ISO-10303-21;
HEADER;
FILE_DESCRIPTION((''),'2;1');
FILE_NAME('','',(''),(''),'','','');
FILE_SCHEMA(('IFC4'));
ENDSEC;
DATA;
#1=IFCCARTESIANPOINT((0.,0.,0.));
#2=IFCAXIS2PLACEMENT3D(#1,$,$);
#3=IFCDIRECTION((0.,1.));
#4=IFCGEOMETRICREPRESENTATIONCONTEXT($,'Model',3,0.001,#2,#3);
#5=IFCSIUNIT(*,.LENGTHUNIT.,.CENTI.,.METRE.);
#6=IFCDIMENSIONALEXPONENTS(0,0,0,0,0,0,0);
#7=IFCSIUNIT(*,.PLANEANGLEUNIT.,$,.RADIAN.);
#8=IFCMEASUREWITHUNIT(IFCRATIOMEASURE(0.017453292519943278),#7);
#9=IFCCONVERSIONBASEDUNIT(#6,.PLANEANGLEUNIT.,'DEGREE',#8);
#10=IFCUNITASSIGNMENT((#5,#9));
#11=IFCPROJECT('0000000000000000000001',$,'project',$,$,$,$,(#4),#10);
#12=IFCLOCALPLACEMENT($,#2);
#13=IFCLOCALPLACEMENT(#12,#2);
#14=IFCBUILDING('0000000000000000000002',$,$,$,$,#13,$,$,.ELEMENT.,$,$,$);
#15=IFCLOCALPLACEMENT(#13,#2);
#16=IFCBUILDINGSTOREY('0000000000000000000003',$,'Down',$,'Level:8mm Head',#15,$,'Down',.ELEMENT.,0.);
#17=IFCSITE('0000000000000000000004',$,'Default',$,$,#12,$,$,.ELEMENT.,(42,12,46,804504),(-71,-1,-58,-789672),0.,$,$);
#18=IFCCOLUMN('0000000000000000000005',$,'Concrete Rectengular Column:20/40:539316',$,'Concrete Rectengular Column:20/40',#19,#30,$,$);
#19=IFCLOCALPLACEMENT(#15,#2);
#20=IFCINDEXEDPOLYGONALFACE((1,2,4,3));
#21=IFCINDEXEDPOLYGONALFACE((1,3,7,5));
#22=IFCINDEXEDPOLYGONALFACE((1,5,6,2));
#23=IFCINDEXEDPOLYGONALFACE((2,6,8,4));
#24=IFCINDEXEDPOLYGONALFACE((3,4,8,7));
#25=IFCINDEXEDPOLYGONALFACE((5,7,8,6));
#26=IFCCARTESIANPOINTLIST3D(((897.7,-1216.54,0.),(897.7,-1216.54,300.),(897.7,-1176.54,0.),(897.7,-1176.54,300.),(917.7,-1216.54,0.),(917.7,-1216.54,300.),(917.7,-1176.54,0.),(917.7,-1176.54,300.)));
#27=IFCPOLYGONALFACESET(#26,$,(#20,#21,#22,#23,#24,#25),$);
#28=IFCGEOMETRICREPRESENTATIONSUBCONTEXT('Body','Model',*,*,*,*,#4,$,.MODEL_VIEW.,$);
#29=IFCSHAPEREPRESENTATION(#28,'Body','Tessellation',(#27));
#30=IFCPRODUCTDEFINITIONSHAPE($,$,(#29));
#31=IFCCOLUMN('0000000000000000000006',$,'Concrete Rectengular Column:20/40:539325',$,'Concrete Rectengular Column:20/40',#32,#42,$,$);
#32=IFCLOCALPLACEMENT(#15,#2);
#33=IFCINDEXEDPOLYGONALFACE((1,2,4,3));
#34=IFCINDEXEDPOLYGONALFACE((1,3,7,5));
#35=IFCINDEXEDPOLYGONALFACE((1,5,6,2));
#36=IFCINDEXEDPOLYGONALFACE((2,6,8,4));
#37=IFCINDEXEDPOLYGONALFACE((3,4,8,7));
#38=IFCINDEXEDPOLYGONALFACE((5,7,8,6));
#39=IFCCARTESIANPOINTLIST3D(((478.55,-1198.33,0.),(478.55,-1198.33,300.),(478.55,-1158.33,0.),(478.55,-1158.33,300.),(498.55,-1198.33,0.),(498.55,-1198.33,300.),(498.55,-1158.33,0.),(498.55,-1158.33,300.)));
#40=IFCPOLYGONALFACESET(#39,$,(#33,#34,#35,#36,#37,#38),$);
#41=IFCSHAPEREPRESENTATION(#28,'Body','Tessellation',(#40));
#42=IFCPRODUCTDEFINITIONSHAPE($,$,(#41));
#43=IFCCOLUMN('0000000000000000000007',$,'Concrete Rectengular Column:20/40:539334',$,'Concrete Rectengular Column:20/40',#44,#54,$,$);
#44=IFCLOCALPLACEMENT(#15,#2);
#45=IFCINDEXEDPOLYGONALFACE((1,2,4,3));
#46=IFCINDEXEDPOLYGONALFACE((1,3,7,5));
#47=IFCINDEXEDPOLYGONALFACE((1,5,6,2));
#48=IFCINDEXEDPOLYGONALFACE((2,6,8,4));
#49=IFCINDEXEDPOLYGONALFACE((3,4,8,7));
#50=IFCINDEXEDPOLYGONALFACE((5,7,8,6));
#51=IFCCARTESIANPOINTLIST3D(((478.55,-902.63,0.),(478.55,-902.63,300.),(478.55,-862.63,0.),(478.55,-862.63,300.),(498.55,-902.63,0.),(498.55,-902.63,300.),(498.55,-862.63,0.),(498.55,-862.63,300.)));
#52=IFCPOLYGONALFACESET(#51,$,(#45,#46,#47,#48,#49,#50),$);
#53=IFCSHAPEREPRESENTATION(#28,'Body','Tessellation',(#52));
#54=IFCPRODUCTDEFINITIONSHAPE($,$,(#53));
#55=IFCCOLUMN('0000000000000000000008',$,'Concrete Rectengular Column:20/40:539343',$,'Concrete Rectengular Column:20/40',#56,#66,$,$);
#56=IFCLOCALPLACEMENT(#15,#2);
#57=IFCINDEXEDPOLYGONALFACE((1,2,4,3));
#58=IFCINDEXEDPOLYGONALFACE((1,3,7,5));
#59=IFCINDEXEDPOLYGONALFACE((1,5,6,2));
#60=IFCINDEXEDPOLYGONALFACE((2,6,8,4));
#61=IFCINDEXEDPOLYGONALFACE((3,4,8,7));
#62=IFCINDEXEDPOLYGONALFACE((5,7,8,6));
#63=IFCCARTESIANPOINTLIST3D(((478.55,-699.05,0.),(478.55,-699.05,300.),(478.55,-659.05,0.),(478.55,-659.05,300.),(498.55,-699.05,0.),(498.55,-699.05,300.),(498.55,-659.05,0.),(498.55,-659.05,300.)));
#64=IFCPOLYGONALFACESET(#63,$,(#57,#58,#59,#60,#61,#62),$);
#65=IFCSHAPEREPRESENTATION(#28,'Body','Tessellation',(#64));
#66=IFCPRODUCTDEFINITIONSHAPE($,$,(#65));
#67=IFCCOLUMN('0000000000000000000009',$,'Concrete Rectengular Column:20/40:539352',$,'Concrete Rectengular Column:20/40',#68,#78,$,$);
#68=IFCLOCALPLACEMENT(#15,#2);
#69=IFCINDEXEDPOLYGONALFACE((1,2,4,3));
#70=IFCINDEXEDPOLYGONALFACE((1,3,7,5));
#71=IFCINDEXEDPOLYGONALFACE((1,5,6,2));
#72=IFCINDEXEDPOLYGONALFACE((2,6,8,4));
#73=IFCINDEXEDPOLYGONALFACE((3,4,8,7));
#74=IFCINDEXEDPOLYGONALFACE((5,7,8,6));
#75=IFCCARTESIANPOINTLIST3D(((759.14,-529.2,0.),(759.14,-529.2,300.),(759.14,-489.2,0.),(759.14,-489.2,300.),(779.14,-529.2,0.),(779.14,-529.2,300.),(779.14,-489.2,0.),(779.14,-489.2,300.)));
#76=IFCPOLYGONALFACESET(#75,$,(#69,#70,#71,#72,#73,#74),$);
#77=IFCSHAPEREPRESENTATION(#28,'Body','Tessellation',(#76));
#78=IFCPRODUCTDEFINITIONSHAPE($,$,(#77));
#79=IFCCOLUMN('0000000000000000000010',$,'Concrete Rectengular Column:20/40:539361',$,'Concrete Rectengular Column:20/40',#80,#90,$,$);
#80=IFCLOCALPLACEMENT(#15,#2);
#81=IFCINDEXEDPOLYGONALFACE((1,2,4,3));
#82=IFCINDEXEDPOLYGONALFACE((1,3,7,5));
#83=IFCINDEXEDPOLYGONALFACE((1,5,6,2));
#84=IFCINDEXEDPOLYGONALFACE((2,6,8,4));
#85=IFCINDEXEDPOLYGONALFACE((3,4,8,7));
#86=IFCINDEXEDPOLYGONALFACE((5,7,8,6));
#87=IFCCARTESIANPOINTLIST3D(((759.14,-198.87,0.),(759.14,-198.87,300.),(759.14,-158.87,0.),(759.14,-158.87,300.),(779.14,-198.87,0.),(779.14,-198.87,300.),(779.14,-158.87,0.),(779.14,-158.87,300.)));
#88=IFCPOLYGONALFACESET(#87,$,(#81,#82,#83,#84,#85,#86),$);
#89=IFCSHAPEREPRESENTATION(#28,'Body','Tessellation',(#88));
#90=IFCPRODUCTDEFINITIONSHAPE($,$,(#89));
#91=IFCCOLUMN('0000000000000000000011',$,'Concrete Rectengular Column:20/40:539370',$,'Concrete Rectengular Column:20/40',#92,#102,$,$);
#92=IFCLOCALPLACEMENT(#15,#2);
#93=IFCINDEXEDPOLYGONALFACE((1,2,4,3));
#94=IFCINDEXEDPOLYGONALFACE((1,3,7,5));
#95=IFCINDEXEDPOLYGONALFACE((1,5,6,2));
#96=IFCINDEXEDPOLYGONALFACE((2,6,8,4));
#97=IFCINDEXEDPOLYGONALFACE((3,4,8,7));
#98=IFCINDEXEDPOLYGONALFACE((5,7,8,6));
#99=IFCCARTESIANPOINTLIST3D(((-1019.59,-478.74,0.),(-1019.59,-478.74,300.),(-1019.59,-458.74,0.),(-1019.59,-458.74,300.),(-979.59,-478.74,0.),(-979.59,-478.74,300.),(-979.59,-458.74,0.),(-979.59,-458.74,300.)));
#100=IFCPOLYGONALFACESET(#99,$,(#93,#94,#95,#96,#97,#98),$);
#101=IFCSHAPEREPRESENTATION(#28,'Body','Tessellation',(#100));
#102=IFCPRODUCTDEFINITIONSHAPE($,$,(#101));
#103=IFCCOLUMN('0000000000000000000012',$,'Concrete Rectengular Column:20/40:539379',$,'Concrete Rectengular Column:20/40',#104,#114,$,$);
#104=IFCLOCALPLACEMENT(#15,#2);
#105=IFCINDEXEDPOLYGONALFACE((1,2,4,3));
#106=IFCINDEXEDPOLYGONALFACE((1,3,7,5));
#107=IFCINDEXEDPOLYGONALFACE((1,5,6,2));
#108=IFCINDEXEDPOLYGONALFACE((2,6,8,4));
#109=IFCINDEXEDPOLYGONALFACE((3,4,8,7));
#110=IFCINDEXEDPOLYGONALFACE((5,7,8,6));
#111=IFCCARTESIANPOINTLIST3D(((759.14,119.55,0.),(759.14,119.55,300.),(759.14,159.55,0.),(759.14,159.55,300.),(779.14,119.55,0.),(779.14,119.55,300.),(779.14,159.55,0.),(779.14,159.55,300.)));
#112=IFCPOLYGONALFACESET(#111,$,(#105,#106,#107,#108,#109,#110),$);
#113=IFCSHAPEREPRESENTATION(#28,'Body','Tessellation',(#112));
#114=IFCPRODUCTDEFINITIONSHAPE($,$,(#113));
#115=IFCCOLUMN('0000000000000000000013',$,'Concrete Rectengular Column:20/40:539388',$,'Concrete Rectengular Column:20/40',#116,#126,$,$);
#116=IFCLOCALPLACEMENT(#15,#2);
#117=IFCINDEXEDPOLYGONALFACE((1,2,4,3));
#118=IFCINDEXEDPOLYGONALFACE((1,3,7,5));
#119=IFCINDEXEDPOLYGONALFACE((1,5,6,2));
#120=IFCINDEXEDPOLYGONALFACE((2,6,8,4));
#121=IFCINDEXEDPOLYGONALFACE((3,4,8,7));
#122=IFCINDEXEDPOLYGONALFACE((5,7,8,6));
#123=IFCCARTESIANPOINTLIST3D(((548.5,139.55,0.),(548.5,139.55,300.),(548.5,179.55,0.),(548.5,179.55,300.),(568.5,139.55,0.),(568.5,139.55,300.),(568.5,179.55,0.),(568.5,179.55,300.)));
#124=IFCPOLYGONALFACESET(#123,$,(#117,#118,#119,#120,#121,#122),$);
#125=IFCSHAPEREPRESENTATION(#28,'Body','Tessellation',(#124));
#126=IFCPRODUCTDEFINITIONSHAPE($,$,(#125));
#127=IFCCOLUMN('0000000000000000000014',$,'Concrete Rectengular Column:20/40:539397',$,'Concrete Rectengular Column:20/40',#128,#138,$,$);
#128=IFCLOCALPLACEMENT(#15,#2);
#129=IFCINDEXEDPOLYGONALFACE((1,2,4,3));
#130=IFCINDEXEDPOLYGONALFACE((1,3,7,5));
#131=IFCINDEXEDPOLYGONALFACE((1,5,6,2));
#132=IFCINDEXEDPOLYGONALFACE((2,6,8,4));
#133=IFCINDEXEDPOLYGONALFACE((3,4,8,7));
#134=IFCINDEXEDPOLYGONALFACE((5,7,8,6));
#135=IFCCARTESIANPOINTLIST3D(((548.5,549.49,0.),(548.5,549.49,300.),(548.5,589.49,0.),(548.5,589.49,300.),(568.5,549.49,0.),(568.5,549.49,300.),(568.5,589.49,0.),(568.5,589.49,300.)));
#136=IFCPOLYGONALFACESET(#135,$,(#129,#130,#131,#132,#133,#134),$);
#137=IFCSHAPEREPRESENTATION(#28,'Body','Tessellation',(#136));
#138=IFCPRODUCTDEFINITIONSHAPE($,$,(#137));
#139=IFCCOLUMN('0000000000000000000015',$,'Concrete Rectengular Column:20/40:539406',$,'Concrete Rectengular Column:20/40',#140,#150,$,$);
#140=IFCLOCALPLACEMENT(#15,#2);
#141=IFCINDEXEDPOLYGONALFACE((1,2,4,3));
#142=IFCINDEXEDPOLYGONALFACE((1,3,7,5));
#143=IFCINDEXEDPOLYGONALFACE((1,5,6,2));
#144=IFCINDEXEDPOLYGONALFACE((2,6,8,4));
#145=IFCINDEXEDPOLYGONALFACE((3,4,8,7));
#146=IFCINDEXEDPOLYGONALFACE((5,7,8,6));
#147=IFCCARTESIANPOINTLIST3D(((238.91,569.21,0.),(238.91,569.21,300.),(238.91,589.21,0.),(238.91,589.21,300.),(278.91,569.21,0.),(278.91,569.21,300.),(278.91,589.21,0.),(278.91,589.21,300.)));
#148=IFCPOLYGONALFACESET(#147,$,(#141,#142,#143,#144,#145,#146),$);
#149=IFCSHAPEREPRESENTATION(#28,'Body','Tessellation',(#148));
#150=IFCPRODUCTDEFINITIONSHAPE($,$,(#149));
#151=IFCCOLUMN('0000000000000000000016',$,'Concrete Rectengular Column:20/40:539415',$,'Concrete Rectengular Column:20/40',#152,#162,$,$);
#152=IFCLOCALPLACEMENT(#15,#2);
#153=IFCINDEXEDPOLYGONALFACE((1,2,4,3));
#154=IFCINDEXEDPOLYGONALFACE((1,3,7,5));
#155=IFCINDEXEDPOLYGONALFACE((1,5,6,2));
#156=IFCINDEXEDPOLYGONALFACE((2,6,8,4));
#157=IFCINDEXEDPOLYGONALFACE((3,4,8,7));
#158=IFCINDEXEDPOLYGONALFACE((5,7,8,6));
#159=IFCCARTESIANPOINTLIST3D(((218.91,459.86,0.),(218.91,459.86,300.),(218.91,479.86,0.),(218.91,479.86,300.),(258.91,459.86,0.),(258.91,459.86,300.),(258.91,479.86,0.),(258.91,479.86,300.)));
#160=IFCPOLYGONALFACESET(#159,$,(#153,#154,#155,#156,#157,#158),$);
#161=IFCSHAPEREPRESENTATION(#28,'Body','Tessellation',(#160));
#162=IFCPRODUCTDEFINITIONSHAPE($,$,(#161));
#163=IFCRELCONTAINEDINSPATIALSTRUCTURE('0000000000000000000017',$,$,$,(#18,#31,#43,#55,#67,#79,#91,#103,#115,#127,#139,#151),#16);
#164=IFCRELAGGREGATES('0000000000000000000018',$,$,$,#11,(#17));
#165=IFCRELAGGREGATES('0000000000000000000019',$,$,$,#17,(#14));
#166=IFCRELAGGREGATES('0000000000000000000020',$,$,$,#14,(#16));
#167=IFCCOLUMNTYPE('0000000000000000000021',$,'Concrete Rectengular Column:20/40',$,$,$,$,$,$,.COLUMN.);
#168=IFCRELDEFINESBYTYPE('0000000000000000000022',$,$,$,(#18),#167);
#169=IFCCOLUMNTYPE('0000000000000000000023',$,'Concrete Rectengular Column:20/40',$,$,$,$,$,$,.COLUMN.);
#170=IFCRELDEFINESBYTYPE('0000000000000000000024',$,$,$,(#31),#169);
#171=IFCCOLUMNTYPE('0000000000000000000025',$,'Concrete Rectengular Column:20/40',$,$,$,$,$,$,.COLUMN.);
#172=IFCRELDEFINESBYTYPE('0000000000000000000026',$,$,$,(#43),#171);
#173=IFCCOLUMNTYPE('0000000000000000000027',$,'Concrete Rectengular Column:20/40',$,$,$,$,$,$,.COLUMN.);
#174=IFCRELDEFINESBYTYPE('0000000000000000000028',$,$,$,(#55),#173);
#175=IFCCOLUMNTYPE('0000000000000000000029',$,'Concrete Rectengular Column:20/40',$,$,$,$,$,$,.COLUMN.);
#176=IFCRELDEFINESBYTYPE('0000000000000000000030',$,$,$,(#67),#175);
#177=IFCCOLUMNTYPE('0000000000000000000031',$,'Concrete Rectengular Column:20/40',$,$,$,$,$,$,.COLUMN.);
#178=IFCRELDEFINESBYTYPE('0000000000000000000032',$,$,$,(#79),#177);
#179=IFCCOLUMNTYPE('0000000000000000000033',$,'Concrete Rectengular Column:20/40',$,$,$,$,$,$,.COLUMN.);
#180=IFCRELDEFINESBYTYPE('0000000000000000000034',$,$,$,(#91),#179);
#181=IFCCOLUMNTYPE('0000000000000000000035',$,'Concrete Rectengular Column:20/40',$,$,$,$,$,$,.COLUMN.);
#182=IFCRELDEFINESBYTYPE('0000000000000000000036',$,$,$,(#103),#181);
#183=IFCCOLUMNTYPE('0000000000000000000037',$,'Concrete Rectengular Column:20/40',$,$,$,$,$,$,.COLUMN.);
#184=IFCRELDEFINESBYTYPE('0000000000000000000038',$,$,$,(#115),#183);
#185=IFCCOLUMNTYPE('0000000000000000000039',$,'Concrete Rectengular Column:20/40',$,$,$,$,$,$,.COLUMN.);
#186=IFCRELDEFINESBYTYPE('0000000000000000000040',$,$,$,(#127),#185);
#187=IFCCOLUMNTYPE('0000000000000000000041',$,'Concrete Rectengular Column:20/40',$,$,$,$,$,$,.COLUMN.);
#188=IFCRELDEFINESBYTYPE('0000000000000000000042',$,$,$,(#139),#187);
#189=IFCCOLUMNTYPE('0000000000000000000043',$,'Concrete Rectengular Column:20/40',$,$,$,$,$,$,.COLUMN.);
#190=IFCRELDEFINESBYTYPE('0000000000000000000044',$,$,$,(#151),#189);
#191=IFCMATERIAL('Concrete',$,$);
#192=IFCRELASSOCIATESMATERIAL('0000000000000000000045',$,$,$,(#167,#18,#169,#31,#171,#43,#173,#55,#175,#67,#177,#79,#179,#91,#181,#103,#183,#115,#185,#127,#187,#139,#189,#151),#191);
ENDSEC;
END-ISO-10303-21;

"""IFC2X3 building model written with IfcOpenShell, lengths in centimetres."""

from ifc_helpers import new_model, entity, si_unit, converted_unit, direction, frame, frame_2d, origin, origin_2d_with_axis, place, context, subcontext, project, spatial, rectangle, extrude, source, transform, mapped, material, type_object, type_shapes, element, save


model = new_model("IFC2X3")

# Units and contexts
model_context = context("Model", 3, precision=0.001, world=origin(), true_north=direction((0.0, 1.0)))
body_context = subcontext(model_context, "Body", "Model", "MODEL_VIEW")
ifc_project = project(units=[si_unit("LENGTHUNIT", "METRE", prefix="CENTI"), converted_unit("PLANEANGLEUNIT", "DEGREE", entity("IfcRatioMeasure", 0.017453292519943278), si_unit("PLANEANGLEUNIT", "RADIAN"), dimensions=[0, 0, 0, 0, 0, 0, 0])], contexts=[model_context])

# Site, building, storey
site_placement = place(None, origin())
site = spatial("IfcSite", under=ifc_project, at=site_placement, Name="Default", CompositionType="ELEMENT", RefLatitude=(42, 12, 46, 804504), RefLongitude=(-71, -1, -58, -789672), RefElevation=0.0)
building_placement = place(site_placement, origin())
building = spatial("IfcBuilding", under=site, at=building_placement, CompositionType="ELEMENT")
storey_placement = place(building_placement, origin())
storey = spatial("IfcBuildingStorey", under=building, at=storey_placement, Name="Down", ObjectType="Level:8mm Head", LongName="Down", CompositionType="ELEMENT", Elevation=0.0)

# Columns
ifc_material = material(Name="Concrete")
column_type_1 = type_object("IfcColumnType", Name="Concrete Rectengular Column:20/40", PredefinedType="COLUMN", material=ifc_material)
shared_shape_1 = source(origin(), body_context, "Body", "SweptSolid", [
    extrude(rectangle(XDim=40.0, YDim=20.0, at=origin_2d_with_axis()), frame((907.7, -1196.54, 0.0), z_axis=(0.0, 0.0, 1.0), x_axis=(0.0, -1.0, 0.0)), (0.0, 0.0, 1.0), 300.0),
])
type_shapes(column_type_1, [shared_shape_1])
column_1_placement = place(storey_placement, origin())
element("IfcColumn", 1, at=column_1_placement, inside=storey, type_object=column_type_1, material=ifc_material, Name="Concrete Rectengular Column:20/40:539316", ObjectType="Concrete Rectengular Column:20/40", context=body_context, shape_type="MappedRepresentation", body=[
    mapped(shared_shape_1, transform((0.0, 0.0, 0.0), scale=1.0)),
])
column_type_2 = type_object("IfcColumnType", Name="Concrete Rectengular Column:20/40", PredefinedType="COLUMN", material=ifc_material)
shared_shape_2 = source(origin(), body_context, "Body", "SweptSolid", [
    extrude(rectangle(XDim=40.0, YDim=20.0, at=frame_2d((0.0, 0.0), x_axis=(1.0, 0.0))), frame((488.55, -1178.33, 0.0), z_axis=(0.0, 0.0, 1.0), x_axis=(0.0, -1.0, 0.0)), (0.0, 0.0, 1.0), 300.0),
])
type_shapes(column_type_2, [shared_shape_2])
column_2_placement = place(storey_placement, origin())
element("IfcColumn", 2, at=column_2_placement, inside=storey, type_object=column_type_2, material=ifc_material, Name="Concrete Rectengular Column:20/40:539325", ObjectType="Concrete Rectengular Column:20/40", context=body_context, shape_type="MappedRepresentation", body=[
    mapped(shared_shape_2, transform((0.0, 0.0, 0.0), scale=1.0)),
])
column_type_3 = type_object("IfcColumnType", Name="Concrete Rectengular Column:20/40", PredefinedType="COLUMN", material=ifc_material)
shared_shape_3 = source(origin(), body_context, "Body", "SweptSolid", [
    extrude(rectangle(XDim=40.0, YDim=20.0, at=origin_2d_with_axis()), frame((488.55, -882.63, 0.0), z_axis=(0.0, 0.0, 1.0), x_axis=(0.0, -1.0, 0.0)), (0.0, 0.0, 1.0), 300.0),
])
type_shapes(column_type_3, [shared_shape_3])
column_3_placement = place(storey_placement, origin())
element("IfcColumn", 3, at=column_3_placement, inside=storey, type_object=column_type_3, material=ifc_material, Name="Concrete Rectengular Column:20/40:539334", ObjectType="Concrete Rectengular Column:20/40", context=body_context, shape_type="MappedRepresentation", body=[
    mapped(shared_shape_3, transform((0.0, 0.0, 0.0), scale=1.0)),
])
column_type_4 = type_object("IfcColumnType", Name="Concrete Rectengular Column:20/40", PredefinedType="COLUMN", material=ifc_material)
shared_shape_4 = source(origin(), body_context, "Body", "SweptSolid", [
    extrude(rectangle(XDim=40.0, YDim=20.0, at=origin_2d_with_axis()), frame((488.55, -679.05, 0.0), z_axis=(0.0, 0.0, 1.0), x_axis=(0.0, -1.0, 0.0)), (0.0, 0.0, 1.0), 300.0),
])
type_shapes(column_type_4, [shared_shape_4])
column_4_placement = place(storey_placement, origin())
element("IfcColumn", 4, at=column_4_placement, inside=storey, type_object=column_type_4, material=ifc_material, Name="Concrete Rectengular Column:20/40:539343", ObjectType="Concrete Rectengular Column:20/40", context=body_context, shape_type="MappedRepresentation", body=[
    mapped(shared_shape_4, transform((0.0, 0.0, 0.0), scale=1.0)),
])
column_type_5 = type_object("IfcColumnType", Name="Concrete Rectengular Column:20/40", PredefinedType="COLUMN", material=ifc_material)
shared_shape_5 = source(origin(), body_context, "Body", "SweptSolid", [
    extrude(rectangle(XDim=40.0, YDim=20.0, at=origin_2d_with_axis()), frame((769.14, -509.2, 0.0), z_axis=(0.0, 0.0, 1.0), x_axis=(0.0, -1.0, 0.0)), (0.0, 0.0, 1.0), 300.0),
])
type_shapes(column_type_5, [shared_shape_5])
column_5_placement = place(storey_placement, origin())
element("IfcColumn", 5, at=column_5_placement, inside=storey, type_object=column_type_5, material=ifc_material, Name="Concrete Rectengular Column:20/40:539352", ObjectType="Concrete Rectengular Column:20/40", context=body_context, shape_type="MappedRepresentation", body=[
    mapped(shared_shape_5, transform((0.0, 0.0, 0.0), scale=1.0)),
])
column_type_6 = type_object("IfcColumnType", Name="Concrete Rectengular Column:20/40", PredefinedType="COLUMN", material=ifc_material)
shared_shape_6 = source(origin(), body_context, "Body", "SweptSolid", [
    extrude(rectangle(XDim=40.0, YDim=20.0, at=origin_2d_with_axis()), frame((769.14, -178.87, 0.0), z_axis=(0.0, 0.0, 1.0), x_axis=(0.0, -1.0, 0.0)), (0.0, 0.0, 1.0), 300.0),
])
type_shapes(column_type_6, [shared_shape_6])
column_6_placement = place(storey_placement, origin())
element("IfcColumn", 6, at=column_6_placement, inside=storey, type_object=column_type_6, material=ifc_material, Name="Concrete Rectengular Column:20/40:539361", ObjectType="Concrete Rectengular Column:20/40", context=body_context, shape_type="MappedRepresentation", body=[
    mapped(shared_shape_6, transform((0.0, 0.0, 0.0), scale=1.0)),
])
column_type_7 = type_object("IfcColumnType", Name="Concrete Rectengular Column:20/40", PredefinedType="COLUMN", material=ifc_material)
shared_shape_7 = source(origin(), body_context, "Body", "SweptSolid", [
    extrude(rectangle(XDim=20.0, YDim=40.0, at=origin_2d_with_axis()), frame((-999.59, -468.74, 0.0), z_axis=(0.0, 0.0, 1.0), x_axis=(0.0, -1.0, 0.0)), (0.0, 0.0, 1.0), 300.0),
])
type_shapes(column_type_7, [shared_shape_7])
column_7_placement = place(storey_placement, origin())
element("IfcColumn", 7, at=column_7_placement, inside=storey, type_object=column_type_7, material=ifc_material, Name="Concrete Rectengular Column:20/40:539370", ObjectType="Concrete Rectengular Column:20/40", context=body_context, shape_type="MappedRepresentation", body=[
    mapped(shared_shape_7, transform((0.0, 0.0, 0.0), scale=1.0)),
])
column_type_8 = type_object("IfcColumnType", Name="Concrete Rectengular Column:20/40", PredefinedType="COLUMN", material=ifc_material)
shared_shape_8 = source(origin(), body_context, "Body", "SweptSolid", [
    extrude(rectangle(XDim=40.0, YDim=20.0, at=frame_2d((0.0, 0.0), x_axis=(1.0, 0.0))), frame((769.14, 139.55, 0.0), z_axis=(0.0, 0.0, 1.0), x_axis=(0.0, -1.0, 0.0)), (0.0, 0.0, 1.0), 300.0),
])
type_shapes(column_type_8, [shared_shape_8])
column_8_placement = place(storey_placement, origin())
element("IfcColumn", 8, at=column_8_placement, inside=storey, type_object=column_type_8, material=ifc_material, Name="Concrete Rectengular Column:20/40:539379", ObjectType="Concrete Rectengular Column:20/40", context=body_context, shape_type="MappedRepresentation", body=[
    mapped(shared_shape_8, transform((0.0, 0.0, 0.0), scale=1.0)),
])
column_type_9 = type_object("IfcColumnType", Name="Concrete Rectengular Column:20/40", PredefinedType="COLUMN", material=ifc_material)
shared_shape_9 = source(origin(), body_context, "Body", "SweptSolid", [
    extrude(rectangle(XDim=40.0, YDim=20.0, at=origin_2d_with_axis()), frame((558.5, 159.55, 0.0), z_axis=(0.0, 0.0, 1.0), x_axis=(0.0, -1.0, 0.0)), (0.0, 0.0, 1.0), 300.0),
])
type_shapes(column_type_9, [shared_shape_9])
column_9_placement = place(storey_placement, origin())
element("IfcColumn", 9, at=column_9_placement, inside=storey, type_object=column_type_9, material=ifc_material, Name="Concrete Rectengular Column:20/40:539388", ObjectType="Concrete Rectengular Column:20/40", context=body_context, shape_type="MappedRepresentation", body=[
    mapped(shared_shape_9, transform((0.0, 0.0, 0.0), scale=1.0)),
])
column_type_10 = type_object("IfcColumnType", Name="Concrete Rectengular Column:20/40", PredefinedType="COLUMN", material=ifc_material)
shared_shape_10 = source(origin(), body_context, "Body", "SweptSolid", [
    extrude(rectangle(XDim=40.0, YDim=20.0, at=origin_2d_with_axis()), frame((558.5, 569.49, 0.0), z_axis=(0.0, 0.0, 1.0), x_axis=(0.0, -1.0, 0.0)), (0.0, 0.0, 1.0), 300.0),
])
type_shapes(column_type_10, [shared_shape_10])
column_10_placement = place(storey_placement, origin())
element("IfcColumn", 10, at=column_10_placement, inside=storey, type_object=column_type_10, material=ifc_material, Name="Concrete Rectengular Column:20/40:539397", ObjectType="Concrete Rectengular Column:20/40", context=body_context, shape_type="MappedRepresentation", body=[
    mapped(shared_shape_10, transform((0.0, 0.0, 0.0), scale=1.0)),
])
column_type_11 = type_object("IfcColumnType", Name="Concrete Rectengular Column:20/40", PredefinedType="COLUMN", material=ifc_material)
shared_shape_11 = source(origin(), body_context, "Body", "SweptSolid", [
    extrude(rectangle(XDim=20.0, YDim=40.0, at=origin_2d_with_axis()), frame((258.91, 579.21, 0.0), z_axis=(0.0, 0.0, 1.0), x_axis=(0.0, -1.0, 0.0)), (0.0, 0.0, 1.0), 300.0),
])
type_shapes(column_type_11, [shared_shape_11])
column_11_placement = place(storey_placement, origin())
element("IfcColumn", 11, at=column_11_placement, inside=storey, type_object=column_type_11, material=ifc_material, Name="Concrete Rectengular Column:20/40:539406", ObjectType="Concrete Rectengular Column:20/40", context=body_context, shape_type="MappedRepresentation", body=[
    mapped(shared_shape_11, transform((0.0, 0.0, 0.0), scale=1.0)),
])
column_type_12 = type_object("IfcColumnType", Name="Concrete Rectengular Column:20/40", PredefinedType="COLUMN", material=ifc_material)
shared_shape_12 = source(origin(), body_context, "Body", "SweptSolid", [
    extrude(rectangle(XDim=20.0, YDim=40.0, at=origin_2d_with_axis()), frame((238.91, 469.86, 0.0), z_axis=(0.0, 0.0, 1.0), x_axis=(0.0, -1.0, 0.0)), (0.0, 0.0, 1.0), 300.0),
])
type_shapes(column_type_12, [shared_shape_12])
column_12_placement = place(storey_placement, origin())
element("IfcColumn", 12, at=column_12_placement, inside=storey, type_object=column_type_12, material=ifc_material, Name="Concrete Rectengular Column:20/40:539415", ObjectType="Concrete Rectengular Column:20/40", context=body_context, shape_type="MappedRepresentation", body=[
    mapped(shared_shape_12, transform((0.0, 0.0, 0.0), scale=1.0)),
])

save(model, "model.ifc")
